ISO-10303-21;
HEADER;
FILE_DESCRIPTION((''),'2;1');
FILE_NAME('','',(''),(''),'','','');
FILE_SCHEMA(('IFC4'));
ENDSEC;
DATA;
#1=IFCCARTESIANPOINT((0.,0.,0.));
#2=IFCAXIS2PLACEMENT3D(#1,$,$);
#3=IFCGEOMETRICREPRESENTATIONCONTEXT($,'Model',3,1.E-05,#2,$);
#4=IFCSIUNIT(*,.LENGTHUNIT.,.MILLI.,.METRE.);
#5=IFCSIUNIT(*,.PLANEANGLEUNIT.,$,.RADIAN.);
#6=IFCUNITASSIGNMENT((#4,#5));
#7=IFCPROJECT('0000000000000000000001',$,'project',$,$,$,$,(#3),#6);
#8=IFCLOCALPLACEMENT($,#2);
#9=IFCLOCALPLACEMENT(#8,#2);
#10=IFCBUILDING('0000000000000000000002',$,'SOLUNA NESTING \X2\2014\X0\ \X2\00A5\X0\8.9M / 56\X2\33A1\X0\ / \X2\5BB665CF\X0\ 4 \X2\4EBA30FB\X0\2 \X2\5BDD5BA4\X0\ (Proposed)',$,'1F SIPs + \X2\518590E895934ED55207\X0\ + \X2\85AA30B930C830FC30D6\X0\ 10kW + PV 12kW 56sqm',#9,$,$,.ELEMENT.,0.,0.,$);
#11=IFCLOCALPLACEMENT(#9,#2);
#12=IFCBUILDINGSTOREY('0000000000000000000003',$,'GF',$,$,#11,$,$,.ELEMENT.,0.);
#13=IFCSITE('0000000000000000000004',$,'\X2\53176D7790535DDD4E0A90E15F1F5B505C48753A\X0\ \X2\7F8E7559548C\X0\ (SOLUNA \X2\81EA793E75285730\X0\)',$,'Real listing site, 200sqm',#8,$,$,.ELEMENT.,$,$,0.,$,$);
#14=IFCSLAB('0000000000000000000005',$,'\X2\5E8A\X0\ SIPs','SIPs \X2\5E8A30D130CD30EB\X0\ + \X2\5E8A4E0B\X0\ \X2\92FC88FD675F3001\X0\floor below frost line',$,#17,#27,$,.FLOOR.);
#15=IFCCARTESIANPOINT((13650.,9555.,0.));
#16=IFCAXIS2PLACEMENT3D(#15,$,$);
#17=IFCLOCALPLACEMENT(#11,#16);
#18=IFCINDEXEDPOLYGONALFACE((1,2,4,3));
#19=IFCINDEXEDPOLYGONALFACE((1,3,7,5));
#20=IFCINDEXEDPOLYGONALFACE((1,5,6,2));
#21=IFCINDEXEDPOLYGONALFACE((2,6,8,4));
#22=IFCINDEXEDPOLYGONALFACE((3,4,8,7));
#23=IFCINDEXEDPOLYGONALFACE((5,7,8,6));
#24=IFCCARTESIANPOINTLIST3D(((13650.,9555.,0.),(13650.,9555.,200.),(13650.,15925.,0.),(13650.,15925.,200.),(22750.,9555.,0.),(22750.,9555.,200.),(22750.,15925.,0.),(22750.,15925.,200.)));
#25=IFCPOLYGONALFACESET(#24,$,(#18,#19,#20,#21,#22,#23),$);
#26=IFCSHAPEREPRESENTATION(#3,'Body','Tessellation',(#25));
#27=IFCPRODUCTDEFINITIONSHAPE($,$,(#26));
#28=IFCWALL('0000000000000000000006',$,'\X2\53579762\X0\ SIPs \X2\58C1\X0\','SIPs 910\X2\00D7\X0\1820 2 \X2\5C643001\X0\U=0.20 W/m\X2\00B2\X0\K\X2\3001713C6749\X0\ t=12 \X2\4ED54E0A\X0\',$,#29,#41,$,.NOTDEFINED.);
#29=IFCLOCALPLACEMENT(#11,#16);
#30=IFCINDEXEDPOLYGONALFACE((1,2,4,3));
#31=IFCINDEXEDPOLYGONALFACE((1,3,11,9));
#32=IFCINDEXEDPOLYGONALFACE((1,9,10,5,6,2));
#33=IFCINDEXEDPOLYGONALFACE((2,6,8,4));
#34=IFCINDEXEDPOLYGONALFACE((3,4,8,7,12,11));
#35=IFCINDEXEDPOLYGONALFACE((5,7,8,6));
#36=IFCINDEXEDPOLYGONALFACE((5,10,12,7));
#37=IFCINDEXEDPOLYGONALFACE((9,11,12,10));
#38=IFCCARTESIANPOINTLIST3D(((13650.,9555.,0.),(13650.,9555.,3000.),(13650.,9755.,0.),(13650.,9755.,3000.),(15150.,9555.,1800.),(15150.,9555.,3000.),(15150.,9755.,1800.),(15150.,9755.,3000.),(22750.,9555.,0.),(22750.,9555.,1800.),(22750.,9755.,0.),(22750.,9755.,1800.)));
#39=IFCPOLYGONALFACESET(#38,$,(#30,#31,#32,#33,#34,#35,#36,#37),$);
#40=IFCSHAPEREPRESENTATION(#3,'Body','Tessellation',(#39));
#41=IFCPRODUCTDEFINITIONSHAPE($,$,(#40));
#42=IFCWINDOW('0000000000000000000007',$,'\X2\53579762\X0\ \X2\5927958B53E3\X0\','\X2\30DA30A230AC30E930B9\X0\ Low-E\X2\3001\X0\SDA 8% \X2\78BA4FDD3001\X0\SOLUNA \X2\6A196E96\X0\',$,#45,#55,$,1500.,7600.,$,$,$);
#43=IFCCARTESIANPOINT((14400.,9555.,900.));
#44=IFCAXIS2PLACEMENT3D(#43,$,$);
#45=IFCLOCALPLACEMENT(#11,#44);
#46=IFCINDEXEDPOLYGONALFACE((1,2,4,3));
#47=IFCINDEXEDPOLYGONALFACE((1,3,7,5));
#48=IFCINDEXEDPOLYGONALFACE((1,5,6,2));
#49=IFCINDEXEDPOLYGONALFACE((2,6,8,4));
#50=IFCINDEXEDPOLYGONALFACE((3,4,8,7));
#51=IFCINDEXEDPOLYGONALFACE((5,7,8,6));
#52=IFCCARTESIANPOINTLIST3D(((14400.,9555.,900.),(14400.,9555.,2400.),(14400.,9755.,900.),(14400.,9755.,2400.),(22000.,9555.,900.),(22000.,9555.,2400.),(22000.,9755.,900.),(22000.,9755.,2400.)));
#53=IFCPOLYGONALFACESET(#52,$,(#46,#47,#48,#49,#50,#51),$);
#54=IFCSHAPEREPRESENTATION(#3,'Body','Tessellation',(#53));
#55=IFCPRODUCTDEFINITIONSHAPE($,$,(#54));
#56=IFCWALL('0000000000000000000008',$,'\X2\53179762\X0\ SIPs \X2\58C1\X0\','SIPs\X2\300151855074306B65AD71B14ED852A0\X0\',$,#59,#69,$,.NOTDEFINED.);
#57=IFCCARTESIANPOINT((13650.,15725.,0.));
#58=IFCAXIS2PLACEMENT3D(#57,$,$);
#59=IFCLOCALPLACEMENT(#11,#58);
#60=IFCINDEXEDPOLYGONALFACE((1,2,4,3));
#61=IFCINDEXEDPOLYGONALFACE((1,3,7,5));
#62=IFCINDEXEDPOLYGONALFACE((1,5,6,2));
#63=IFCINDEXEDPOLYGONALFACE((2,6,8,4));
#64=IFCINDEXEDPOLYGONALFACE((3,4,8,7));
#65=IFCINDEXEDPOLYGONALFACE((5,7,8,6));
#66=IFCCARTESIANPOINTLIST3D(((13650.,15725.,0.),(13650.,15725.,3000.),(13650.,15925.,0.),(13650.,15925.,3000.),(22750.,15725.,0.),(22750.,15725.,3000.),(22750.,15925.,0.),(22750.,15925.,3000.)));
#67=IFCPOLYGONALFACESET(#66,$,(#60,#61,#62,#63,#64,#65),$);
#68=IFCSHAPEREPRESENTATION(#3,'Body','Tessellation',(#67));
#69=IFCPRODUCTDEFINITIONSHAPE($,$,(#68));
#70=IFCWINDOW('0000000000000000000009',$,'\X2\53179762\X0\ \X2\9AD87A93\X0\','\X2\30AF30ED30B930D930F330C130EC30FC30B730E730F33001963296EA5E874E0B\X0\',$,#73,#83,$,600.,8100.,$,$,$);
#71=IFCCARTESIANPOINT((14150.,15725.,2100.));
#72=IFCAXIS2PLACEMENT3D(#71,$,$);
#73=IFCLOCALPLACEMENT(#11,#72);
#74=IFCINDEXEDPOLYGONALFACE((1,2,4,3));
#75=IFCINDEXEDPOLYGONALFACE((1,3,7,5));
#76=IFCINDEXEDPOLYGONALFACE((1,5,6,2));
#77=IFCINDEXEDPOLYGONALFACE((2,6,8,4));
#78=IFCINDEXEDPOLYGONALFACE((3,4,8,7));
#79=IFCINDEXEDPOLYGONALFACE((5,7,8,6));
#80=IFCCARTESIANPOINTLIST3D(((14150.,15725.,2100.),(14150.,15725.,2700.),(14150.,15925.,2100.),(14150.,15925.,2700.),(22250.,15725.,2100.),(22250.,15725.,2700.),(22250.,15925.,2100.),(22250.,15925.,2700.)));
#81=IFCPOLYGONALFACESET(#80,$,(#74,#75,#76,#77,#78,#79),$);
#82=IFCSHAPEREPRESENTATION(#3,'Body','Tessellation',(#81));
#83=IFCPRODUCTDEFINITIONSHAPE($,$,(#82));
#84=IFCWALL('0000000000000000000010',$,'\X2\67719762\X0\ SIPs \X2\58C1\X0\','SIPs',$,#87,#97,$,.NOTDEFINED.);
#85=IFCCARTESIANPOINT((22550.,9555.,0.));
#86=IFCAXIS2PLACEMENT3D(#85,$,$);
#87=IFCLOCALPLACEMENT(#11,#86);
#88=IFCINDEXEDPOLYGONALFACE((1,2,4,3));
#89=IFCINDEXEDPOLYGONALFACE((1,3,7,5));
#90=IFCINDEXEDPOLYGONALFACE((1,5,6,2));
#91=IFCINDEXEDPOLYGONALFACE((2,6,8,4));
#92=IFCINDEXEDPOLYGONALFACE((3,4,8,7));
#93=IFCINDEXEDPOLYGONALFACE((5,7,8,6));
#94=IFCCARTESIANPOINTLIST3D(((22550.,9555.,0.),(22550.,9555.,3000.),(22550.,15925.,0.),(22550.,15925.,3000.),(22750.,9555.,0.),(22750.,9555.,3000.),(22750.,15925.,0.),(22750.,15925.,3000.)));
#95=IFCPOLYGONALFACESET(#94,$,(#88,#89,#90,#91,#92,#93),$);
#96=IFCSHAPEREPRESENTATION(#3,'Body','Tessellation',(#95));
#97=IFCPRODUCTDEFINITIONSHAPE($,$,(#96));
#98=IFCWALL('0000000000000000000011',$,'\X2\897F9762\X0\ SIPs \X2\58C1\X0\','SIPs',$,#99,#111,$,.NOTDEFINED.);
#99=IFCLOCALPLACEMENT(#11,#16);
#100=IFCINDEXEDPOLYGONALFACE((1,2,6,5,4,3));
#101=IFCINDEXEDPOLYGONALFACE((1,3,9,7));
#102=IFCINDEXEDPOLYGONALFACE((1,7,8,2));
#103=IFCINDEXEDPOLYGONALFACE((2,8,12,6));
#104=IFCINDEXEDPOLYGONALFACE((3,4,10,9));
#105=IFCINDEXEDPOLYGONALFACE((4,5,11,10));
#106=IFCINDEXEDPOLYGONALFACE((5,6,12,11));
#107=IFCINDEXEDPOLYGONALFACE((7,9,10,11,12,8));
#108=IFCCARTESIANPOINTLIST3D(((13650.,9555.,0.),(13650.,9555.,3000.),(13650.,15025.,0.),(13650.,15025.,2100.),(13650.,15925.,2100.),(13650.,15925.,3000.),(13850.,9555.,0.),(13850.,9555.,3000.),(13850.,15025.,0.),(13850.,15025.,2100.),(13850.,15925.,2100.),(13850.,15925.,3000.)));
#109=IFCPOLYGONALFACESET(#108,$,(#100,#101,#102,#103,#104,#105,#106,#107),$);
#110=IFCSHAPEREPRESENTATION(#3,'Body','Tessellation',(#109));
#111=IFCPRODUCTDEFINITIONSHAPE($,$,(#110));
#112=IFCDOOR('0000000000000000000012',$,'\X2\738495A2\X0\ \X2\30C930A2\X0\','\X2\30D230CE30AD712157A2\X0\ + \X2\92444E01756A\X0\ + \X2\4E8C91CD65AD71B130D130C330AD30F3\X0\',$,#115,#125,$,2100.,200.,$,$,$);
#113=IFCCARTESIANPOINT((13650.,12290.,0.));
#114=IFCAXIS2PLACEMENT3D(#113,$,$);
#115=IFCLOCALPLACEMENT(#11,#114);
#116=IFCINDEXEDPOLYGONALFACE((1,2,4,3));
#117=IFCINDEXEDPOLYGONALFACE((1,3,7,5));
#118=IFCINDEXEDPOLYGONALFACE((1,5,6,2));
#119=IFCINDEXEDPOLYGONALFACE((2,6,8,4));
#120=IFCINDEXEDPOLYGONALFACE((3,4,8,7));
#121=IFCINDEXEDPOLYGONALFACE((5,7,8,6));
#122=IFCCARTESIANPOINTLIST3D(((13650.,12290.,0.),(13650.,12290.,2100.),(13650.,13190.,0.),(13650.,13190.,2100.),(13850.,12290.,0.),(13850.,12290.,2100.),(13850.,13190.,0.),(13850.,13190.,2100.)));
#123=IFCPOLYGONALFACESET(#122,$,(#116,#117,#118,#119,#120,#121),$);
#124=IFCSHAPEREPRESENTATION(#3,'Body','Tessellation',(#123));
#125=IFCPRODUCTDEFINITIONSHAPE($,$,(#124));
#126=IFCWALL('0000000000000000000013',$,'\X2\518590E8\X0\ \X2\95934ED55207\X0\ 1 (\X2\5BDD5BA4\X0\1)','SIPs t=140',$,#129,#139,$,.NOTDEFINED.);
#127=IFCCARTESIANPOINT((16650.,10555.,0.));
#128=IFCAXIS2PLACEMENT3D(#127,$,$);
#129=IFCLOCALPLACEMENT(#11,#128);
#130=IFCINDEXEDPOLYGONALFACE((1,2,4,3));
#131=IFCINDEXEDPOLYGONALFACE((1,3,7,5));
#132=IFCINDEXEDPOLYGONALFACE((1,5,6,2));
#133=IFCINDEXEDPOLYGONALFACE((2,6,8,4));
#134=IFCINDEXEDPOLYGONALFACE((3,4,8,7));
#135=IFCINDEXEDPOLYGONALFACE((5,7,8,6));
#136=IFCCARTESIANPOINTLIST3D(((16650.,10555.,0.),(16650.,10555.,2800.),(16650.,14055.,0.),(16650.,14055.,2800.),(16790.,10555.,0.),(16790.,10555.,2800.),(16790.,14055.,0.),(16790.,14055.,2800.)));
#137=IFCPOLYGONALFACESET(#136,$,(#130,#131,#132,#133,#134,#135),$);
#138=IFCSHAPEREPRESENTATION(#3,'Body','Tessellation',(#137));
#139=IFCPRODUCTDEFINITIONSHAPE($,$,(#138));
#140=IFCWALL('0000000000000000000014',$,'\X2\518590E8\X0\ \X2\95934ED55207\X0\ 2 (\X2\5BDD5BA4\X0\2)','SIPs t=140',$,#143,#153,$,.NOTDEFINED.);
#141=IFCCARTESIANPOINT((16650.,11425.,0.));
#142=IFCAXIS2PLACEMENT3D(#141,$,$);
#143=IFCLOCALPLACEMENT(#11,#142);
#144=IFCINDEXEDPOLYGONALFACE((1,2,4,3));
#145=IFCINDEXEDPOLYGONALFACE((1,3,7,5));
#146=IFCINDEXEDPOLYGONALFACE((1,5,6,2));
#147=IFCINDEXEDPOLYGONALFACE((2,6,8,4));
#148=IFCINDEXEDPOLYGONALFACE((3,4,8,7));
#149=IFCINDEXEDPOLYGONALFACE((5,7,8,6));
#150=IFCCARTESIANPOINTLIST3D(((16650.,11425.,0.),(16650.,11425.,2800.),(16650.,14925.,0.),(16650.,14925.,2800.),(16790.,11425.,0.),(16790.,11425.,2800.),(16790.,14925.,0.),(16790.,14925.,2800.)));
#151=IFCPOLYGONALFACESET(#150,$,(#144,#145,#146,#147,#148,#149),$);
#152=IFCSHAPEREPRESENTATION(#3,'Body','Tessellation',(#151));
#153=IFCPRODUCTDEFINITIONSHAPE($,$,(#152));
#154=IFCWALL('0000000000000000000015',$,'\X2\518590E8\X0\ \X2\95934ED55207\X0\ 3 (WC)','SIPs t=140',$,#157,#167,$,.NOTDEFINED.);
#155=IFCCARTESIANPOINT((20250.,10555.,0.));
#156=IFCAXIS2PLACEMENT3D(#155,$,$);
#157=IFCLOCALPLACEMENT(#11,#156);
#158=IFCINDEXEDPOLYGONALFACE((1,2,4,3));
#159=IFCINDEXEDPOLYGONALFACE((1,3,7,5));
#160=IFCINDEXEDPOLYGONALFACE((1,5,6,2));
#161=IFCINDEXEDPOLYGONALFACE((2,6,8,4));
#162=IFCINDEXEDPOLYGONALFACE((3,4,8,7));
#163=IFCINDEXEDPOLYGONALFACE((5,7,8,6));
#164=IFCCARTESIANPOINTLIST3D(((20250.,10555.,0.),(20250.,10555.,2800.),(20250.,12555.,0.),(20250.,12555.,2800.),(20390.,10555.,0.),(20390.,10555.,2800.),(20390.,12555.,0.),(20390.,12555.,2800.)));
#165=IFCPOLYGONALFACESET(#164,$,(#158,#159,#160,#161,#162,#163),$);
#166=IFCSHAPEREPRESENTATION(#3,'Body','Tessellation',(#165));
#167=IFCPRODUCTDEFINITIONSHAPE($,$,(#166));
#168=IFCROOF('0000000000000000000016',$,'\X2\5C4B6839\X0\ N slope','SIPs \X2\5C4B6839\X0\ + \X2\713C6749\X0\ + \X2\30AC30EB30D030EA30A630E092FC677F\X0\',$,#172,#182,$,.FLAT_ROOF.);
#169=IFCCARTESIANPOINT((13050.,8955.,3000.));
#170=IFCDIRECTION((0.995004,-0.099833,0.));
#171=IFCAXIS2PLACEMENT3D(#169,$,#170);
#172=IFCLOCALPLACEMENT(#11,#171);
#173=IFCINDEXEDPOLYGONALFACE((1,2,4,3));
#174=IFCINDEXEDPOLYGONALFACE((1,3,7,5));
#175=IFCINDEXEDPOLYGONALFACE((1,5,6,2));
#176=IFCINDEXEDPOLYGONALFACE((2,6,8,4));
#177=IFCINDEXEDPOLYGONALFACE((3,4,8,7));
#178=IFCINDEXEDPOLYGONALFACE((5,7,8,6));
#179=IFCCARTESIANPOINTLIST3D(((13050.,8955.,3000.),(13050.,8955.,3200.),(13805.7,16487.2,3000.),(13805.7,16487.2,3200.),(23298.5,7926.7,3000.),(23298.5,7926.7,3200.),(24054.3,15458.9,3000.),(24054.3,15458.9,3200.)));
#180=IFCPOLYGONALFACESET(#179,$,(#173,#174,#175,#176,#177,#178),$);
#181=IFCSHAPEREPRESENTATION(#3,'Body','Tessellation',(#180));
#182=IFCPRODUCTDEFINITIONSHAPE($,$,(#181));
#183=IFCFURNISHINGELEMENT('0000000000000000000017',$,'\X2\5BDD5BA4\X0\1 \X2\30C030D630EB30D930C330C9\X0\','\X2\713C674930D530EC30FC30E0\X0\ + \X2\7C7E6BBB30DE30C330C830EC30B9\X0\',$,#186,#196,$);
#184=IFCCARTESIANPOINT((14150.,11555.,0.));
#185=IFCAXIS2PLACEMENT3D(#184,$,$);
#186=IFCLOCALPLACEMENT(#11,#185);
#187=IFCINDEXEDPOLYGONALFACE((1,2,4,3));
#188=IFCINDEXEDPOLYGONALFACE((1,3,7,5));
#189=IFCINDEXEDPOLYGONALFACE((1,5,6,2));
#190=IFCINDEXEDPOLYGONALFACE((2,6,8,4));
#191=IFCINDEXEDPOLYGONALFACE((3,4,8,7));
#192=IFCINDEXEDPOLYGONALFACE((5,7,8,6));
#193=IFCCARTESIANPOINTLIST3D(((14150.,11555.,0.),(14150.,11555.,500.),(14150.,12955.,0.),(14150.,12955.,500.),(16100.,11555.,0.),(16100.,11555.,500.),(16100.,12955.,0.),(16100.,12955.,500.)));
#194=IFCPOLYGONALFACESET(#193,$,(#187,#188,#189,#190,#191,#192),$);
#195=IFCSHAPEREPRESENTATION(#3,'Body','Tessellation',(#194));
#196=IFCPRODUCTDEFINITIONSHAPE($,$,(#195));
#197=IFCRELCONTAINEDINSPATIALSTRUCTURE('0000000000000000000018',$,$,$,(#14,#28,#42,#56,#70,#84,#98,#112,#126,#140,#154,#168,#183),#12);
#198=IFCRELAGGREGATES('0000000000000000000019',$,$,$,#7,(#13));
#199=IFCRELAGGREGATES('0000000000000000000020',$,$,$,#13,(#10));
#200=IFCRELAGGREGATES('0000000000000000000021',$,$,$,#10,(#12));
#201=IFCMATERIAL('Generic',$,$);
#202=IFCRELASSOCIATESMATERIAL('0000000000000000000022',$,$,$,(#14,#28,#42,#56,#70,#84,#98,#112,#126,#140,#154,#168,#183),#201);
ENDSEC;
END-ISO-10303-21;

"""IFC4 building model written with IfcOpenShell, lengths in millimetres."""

from ifc_helpers import new_model, si_unit, frame, frame_2d, origin, place, context, project, spatial, rectangle, extrude, material, element, fill, save


model = new_model("IFC4")

# Units and contexts
model_context = context("Model", 3, precision=1e-05, world=origin())
ifc_project = project(units=[si_unit("LENGTHUNIT", "METRE", prefix="MILLI"), si_unit("PLANEANGLEUNIT", "RADIAN")], contexts=[model_context])

# Site, building, storey
site_placement = place(None, origin())
site = spatial("IfcSite", under=ifc_project, at=site_placement, Name="北海道川上郡弟子屈町 美留和 (SOLUNA 自社用地)", ObjectType="Real listing site, 200sqm", CompositionType="ELEMENT", RefElevation=0.0)
building_placement = place(site_placement, origin())
building = spatial("IfcBuilding", under=site, at=building_placement, Name="SOLUNA NESTING — ¥8.9M / 56㎡ / 家族 4 人・2 寝室 (Proposed)", ObjectType="1F SIPs + 内部間仕切 + 薪ストーブ 10kW + PV 12kW 56sqm", CompositionType="ELEMENT", ElevationOfRefHeight=0.0, ElevationOfTerrain=0.0)
storey_placement = place(building_placement, origin())
storey = spatial("IfcBuildingStorey", under=building, at=storey_placement, Name="GF", CompositionType="ELEMENT", Elevation=0.0)

# Slab
ifc_material = material(Name="Generic")
slab_placement = place(storey_placement, frame((13650.0, 9555.0, 0.0)))
element("IfcSlab", 1, at=slab_placement, inside=storey, material=ifc_material, Name="床 SIPs", Description="SIPs 床パネル + 床下 鋼製束、floor below frost line", PredefinedType="FLOOR", context=model_context, shape_type="SweptSolid", body=[
    extrude(rectangle(XDim=9100.0, YDim=6370.0, at=frame_2d((4550.0, 3185.0))), frame((13650.0, 9555.0, 0.0)), (0.0, 0.0, 1.0), 200.0),
])

# Walls, openings, windows
wall_1_placement = place(storey_placement, frame((13650.0, 9555.0, 0.0)))
wall_1 = element("IfcWall", 2, at=wall_1_placement, inside=storey, material=ifc_material, Name="南面 SIPs 壁", Description="SIPs 910×1820 2 層、U=0.20 W/m²K、焼杉 t=12 仕上", PredefinedType="NOTDEFINED", context=model_context, shape_type="SweptSolid", body=[
    extrude(rectangle(XDim=9100.0, YDim=200.0, at=frame_2d((4550.0, 100.0))), frame((13650.0, 9555.0, 0.0)), (0.0, 0.0, 1.0), 3000.0),
])
opening_1_placement = place(storey_placement, frame((14400.0, 9555.0, 900.0)))
opening_1 = element("IfcOpeningElement", 3, at=opening_1_placement, cuts=wall_1, PredefinedType="NOTDEFINED", context=model_context, shape_type="SweptSolid", body=[
    extrude(rectangle(XDim=7600.0, YDim=200.0, at=frame_2d((3800.0, 100.0))), frame((14400.0, 9555.0, 900.0)), (0.0, 0.0, 1.0), 1500.0),
])
window_1_placement = place(storey_placement, frame((14400.0, 9555.0, 900.0)))
window_1 = element("IfcWindow", 4, at=window_1_placement, inside=storey, material=ifc_material, Name="南面 大開口", Description="ペアガラス Low-E、SDA 8% 確保、SOLUNA 標準", OverallHeight=1500.0, OverallWidth=7600.0, context=model_context, shape_type="SweptSolid", body=[
    extrude(rectangle(XDim=7600.0, YDim=200.0, at=frame_2d((3800.0, 100.0))), frame((14400.0, 9555.0, 900.0)), (0.0, 0.0, 1.0), 1500.0),
])
fill(opening_1, window_1)
wall_2_placement = place(storey_placement, frame((13650.0, 15725.0, 0.0)))
wall_2 = element("IfcWall", 5, at=wall_2_placement, inside=storey, material=ifc_material, Name="北面 SIPs 壁", Description="SIPs、内側に断熱付加", PredefinedType="NOTDEFINED", context=model_context, shape_type="SweptSolid", body=[
    extrude(rectangle(XDim=9100.0, YDim=200.0, at=frame_2d((4550.0, 100.0))), frame((13650.0, 15725.0, 0.0)), (0.0, 0.0, 1.0), 3000.0),
])
opening_2_placement = place(storey_placement, frame((14150.0, 15725.0, 2100.0)))
opening_2 = element("IfcOpeningElement", 6, at=opening_2_placement, cuts=wall_2, PredefinedType="NOTDEFINED", context=model_context, shape_type="SweptSolid", body=[
    extrude(rectangle(XDim=8100.0, YDim=200.0, at=frame_2d((4050.0, 100.0))), frame((14150.0, 15725.0, 2100.0)), (0.0, 0.0, 1.0), 600.0),
])
window_2_placement = place(storey_placement, frame((14150.0, 15725.0, 2100.0)))
window_2 = element("IfcWindow", 7, at=window_2_placement, inside=storey, material=ifc_material, Name="北面 高窓", Description="クロスベンチレーション、防雪庇下", OverallHeight=600.0, OverallWidth=8100.0, context=model_context, shape_type="SweptSolid", body=[
    extrude(rectangle(XDim=8100.0, YDim=200.0, at=frame_2d((4050.0, 100.0))), frame((14150.0, 15725.0, 2100.0)), (0.0, 0.0, 1.0), 600.0),
])
fill(opening_2, window_2)

# Wall
wall_3_placement = place(storey_placement, frame((22550.0, 9555.0, 0.0)))
element("IfcWall", 8, at=wall_3_placement, inside=storey, material=ifc_material, Name="東面 SIPs 壁", Description="SIPs", PredefinedType="NOTDEFINED", context=model_context, shape_type="SweptSolid", body=[
    extrude(rectangle(XDim=200.0, YDim=6370.0, at=frame_2d((100.0, 3185.0))), frame((22550.0, 9555.0, 0.0)), (0.0, 0.0, 1.0), 3000.0),
])

# Wall, opening, door
wall_4_placement = place(storey_placement, frame((13650.0, 9555.0, 0.0)))
wall_4 = element("IfcWall", 9, at=wall_4_placement, inside=storey, material=ifc_material, Name="西面 SIPs 壁", Description="SIPs", PredefinedType="NOTDEFINED", context=model_context, shape_type="SweptSolid", body=[
    extrude(rectangle(XDim=200.0, YDim=6370.0, at=frame_2d((100.0, 3185.0))), frame((13650.0, 9555.0, 0.0)), (0.0, 0.0, 1.0), 3000.0),
])
opening_3_placement = place(storey_placement, frame((13650.0, 12290.0, 0.0)))
opening_3 = element("IfcOpeningElement", 10, at=opening_3_placement, cuts=wall_4, PredefinedType="NOTDEFINED", context=model_context, shape_type="SweptSolid", body=[
    extrude(rectangle(XDim=200.0, YDim=900.0, at=frame_2d((100.0, 450.0))), frame((13650.0, 12290.0, 0.0)), (0.0, 0.0, 1.0), 2100.0),
])
door_placement = place(storey_placement, frame((13650.0, 12290.0, 0.0)))
door = element("IfcDoor", 11, at=door_placement, inside=storey, material=ifc_material, Name="玄関 ドア", Description="ヒノキ無垢 + 鉄丁番 + 二重断熱パッキン", OverallHeight=2100.0, OverallWidth=200.0, context=model_context, shape_type="SweptSolid", body=[
    extrude(rectangle(XDim=200.0, YDim=900.0, at=frame_2d((100.0, 450.0))), frame((13650.0, 12290.0, 0.0)), (0.0, 0.0, 1.0), 2100.0),
])
fill(opening_3, door)

# Walls
wall_5_placement = place(storey_placement, frame((16650.0, 10555.0, 0.0)))
element("IfcWall", 12, at=wall_5_placement, inside=storey, material=ifc_material, Name="内部 間仕切 1 (寝室1)", Description="SIPs t=140", PredefinedType="NOTDEFINED", context=model_context, shape_type="SweptSolid", body=[
    extrude(rectangle(XDim=140.0, YDim=3500.0, at=frame_2d((70.0, 1750.0))), frame((16650.0, 10555.0, 0.0)), (0.0, 0.0, 1.0), 2800.0),
])
wall_6_placement = place(storey_placement, frame((16650.0, 11425.0, 0.0)))
element("IfcWall", 13, at=wall_6_placement, inside=storey, material=ifc_material, Name="内部 間仕切 2 (寝室2)", Description="SIPs t=140", PredefinedType="NOTDEFINED", context=model_context, shape_type="SweptSolid", body=[
    extrude(rectangle(XDim=140.0, YDim=3500.0, at=frame_2d((70.0, 1750.0))), frame((16650.0, 11425.0, 0.0)), (0.0, 0.0, 1.0), 2800.0),
])
wall_7_placement = place(storey_placement, frame((20250.0, 10555.0, 0.0)))
element("IfcWall", 14, at=wall_7_placement, inside=storey, material=ifc_material, Name="内部 間仕切 3 (WC)", Description="SIPs t=140", PredefinedType="NOTDEFINED", context=model_context, shape_type="SweptSolid", body=[
    extrude(rectangle(XDim=140.0, YDim=2000.0, at=frame_2d((70.0, 1000.0))), frame((20250.0, 10555.0, 0.0)), (0.0, 0.0, 1.0), 2800.0),
])

# Roof
roof_placement = place(storey_placement, frame((13050.0, 8955.0, 3000.0), x_axis=(0.995004, -0.099833, 0.0)))
element("IfcRoof", 15, at=roof_placement, inside=storey, material=ifc_material, Name="屋根 N slope", Description="SIPs 屋根 + 焼杉 + ガルバリウム鋼板", PredefinedType="FLAT_ROOF", context=model_context, shape_type="SweptSolid", body=[
    extrude(rectangle(XDim=10300.0, YDim=7570.0, at=frame_2d((5150.0, 3785.0))), frame((13050.0, 8955.0, 3000.0), x_axis=(0.995004, -0.099833, 0.0)), (0.0, 0.0, 1.0), 200.0),
])

# Furnishing element
furnishing_1_placement = place(storey_placement, frame((14150.0, 11555.0, 0.0)))
element("IfcFurnishingElement", 16, at=furnishing_1_placement, inside=storey, material=ifc_material, Name="寝室1 ダブルベッド", Description="焼杉フレーム + 籾殻マットレス", context=model_context, shape_type="SweptSolid", body=[
    extrude(rectangle(XDim=1950.0, YDim=1400.0, at=frame_2d((975.0, 700.0))), frame((14150.0, 11555.0, 0.0)), (0.0, 0.0, 1.0), 500.0),
])

save(model, "model.ifc")
